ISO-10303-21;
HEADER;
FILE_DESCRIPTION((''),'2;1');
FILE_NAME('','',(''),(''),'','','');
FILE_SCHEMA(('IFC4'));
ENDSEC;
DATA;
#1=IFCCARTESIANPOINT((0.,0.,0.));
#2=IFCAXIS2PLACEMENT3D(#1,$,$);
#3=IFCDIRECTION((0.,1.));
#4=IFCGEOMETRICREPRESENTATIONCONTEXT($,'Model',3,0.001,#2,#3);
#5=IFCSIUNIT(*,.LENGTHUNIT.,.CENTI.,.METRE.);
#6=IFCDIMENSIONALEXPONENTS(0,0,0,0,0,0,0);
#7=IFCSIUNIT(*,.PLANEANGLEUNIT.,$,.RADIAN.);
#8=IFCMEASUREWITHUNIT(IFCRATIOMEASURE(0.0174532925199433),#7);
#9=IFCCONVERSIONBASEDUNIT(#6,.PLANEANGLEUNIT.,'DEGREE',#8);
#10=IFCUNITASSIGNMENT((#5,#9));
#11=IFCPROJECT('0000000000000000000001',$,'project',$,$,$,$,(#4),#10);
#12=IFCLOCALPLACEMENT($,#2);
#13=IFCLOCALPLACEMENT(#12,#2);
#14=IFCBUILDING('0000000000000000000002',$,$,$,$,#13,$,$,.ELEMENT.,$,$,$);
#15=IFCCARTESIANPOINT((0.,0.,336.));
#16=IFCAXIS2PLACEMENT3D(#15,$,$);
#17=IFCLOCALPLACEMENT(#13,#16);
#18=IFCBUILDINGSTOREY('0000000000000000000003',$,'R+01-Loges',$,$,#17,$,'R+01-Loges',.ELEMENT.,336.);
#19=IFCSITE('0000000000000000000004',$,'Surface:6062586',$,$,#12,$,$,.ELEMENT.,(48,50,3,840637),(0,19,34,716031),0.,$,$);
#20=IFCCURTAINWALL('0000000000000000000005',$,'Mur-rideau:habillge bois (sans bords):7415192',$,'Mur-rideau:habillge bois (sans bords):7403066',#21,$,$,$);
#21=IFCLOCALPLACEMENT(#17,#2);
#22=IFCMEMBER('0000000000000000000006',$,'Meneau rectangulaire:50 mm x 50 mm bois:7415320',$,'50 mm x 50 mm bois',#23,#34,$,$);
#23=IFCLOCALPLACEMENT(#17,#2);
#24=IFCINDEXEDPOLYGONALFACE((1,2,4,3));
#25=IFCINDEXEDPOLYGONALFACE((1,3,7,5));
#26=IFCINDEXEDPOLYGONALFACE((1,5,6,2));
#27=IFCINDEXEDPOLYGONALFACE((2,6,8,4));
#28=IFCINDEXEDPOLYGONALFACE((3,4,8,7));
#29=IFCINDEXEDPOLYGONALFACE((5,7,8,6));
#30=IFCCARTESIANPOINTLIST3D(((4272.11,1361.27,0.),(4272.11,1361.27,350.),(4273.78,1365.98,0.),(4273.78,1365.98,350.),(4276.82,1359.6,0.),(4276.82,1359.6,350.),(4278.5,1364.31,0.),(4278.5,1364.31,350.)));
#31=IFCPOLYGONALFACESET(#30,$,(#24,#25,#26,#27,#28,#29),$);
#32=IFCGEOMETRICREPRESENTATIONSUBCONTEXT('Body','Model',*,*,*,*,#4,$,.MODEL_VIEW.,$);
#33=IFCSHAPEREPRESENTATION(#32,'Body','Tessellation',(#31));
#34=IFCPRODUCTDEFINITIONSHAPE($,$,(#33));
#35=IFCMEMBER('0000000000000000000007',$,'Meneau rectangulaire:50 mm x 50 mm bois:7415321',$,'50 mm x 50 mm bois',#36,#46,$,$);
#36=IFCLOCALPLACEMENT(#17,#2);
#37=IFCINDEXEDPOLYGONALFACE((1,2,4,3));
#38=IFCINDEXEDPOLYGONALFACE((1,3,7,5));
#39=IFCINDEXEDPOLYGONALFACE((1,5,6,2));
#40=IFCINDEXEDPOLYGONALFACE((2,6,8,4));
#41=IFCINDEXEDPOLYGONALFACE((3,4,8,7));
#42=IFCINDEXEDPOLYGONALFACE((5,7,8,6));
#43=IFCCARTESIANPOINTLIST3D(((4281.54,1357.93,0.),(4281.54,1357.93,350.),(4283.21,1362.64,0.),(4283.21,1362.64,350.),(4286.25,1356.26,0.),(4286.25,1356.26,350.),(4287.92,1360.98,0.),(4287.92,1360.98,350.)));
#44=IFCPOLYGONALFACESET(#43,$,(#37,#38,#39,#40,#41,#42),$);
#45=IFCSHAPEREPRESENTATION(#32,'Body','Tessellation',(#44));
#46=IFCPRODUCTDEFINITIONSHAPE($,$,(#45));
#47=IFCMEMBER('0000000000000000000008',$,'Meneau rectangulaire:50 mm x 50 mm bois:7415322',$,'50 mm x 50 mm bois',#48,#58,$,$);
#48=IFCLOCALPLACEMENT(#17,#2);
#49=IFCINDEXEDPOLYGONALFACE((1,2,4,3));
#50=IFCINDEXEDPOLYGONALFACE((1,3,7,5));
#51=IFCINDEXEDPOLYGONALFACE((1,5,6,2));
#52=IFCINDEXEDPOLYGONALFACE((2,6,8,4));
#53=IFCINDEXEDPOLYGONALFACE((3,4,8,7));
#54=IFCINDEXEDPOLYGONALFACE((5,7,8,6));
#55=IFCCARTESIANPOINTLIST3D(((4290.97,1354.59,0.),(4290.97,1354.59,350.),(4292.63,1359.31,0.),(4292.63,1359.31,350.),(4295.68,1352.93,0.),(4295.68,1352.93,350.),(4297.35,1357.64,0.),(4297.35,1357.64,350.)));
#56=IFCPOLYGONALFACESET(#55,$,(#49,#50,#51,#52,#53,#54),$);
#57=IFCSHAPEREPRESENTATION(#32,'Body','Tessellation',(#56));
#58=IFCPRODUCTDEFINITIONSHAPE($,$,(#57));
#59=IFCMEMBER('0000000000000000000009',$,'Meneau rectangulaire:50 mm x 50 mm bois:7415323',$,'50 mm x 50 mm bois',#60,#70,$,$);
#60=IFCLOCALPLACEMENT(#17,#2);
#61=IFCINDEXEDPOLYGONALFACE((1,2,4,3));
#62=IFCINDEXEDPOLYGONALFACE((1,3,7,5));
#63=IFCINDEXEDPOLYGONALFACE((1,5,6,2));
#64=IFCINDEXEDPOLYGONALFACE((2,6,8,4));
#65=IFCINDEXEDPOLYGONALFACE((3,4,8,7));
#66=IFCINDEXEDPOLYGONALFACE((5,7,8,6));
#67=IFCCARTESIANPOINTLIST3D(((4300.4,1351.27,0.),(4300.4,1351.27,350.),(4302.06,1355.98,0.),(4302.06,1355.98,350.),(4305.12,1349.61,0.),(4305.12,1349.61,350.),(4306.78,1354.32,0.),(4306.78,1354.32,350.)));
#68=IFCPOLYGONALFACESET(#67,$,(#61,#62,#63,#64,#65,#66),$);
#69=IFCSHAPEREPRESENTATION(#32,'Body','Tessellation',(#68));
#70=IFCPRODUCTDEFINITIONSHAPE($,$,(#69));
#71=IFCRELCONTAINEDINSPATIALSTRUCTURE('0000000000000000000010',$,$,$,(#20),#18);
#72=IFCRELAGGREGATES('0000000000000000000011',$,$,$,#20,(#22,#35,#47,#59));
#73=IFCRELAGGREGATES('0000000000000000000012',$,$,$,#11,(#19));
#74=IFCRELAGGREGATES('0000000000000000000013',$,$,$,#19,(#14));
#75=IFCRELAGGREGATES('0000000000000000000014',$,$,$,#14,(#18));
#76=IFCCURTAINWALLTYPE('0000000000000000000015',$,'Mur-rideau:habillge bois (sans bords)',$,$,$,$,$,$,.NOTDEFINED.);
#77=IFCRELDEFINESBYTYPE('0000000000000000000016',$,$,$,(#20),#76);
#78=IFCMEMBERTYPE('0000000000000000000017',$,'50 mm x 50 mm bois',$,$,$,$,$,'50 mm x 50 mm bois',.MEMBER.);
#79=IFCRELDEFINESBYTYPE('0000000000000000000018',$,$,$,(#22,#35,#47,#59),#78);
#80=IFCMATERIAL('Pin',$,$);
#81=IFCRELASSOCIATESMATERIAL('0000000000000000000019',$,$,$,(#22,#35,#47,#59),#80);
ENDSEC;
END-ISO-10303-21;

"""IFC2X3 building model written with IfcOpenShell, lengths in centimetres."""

from ifc_helpers import new_model, entity, si_unit, converted_unit, direction, frame, origin, origin_2d_with_axis, place, context, subcontext, project, spatial, rectangle, extrude, source, transform, mapped, material, type_object, type_shapes, element, aggregate, save


model = new_model("IFC2X3")

# Units and contexts
model_context = context("Model", 3, precision=0.001, world=origin(), true_north=direction((0.0, 1.0)))
body_context = subcontext(model_context, "Body", "Model", "MODEL_VIEW")
ifc_project = project(units=[si_unit("LENGTHUNIT", "METRE", prefix="CENTI"), converted_unit("PLANEANGLEUNIT", "DEGREE", entity("IfcRatioMeasure", 0.0174532925199433), si_unit("PLANEANGLEUNIT", "RADIAN"), dimensions=[0, 0, 0, 0, 0, 0, 0])], contexts=[model_context])

# Site, building, storey
site_placement = place(None, origin())
site = spatial("IfcSite", under=ifc_project, at=site_placement, Name="Surface:6062586", CompositionType="ELEMENT", RefLatitude=(48, 50, 3, 840637), RefLongitude=(0, 19, 34, 716031), RefElevation=0.0)
building_placement = place(site_placement, origin())
building = spatial("IfcBuilding", under=site, at=building_placement, CompositionType="ELEMENT")
storey_placement = place(building_placement, frame((0.0, 0.0, 336.0)))
storey = spatial("IfcBuildingStorey", under=building, at=storey_placement, Name="R+01-Loges", LongName="R+01-Loges", CompositionType="ELEMENT", Elevation=336.0)

# Curtain wall, members
curtain_wall_type = type_object("IfcCurtainWallType", Name="Mur-rideau:habillge bois (sans bords)", PredefinedType="NOTDEFINED")
curtain_wall_placement = place(storey_placement, frame((0.0, 0.0, -336.0)))
curtain_wall = element("IfcCurtainWall", 1, at=curtain_wall_placement, inside=storey, type_object=curtain_wall_type, Name="Mur-rideau:habillge bois (sans bords):7415192", ObjectType="Mur-rideau:habillge bois (sans bords):7403066")
ifc_material_1 = material(Name="Pin")
member_type_1 = type_object("IfcMemberType", Name="50 mm x 50 mm bois", ElementType="50 mm x 50 mm bois", PredefinedType="MEMBER")
shared_shape_1 = source(origin(), body_context, "Body", "SweptSolid", [
    extrude(rectangle(XDim=5.0, YDim=5.0, at=origin_2d_with_axis()), frame((0.0, 0.0, -350.0), z_axis=(0.0, 0.0, 1.0), x_axis=(0.0, -1.0, 0.0)), (0.0, 0.0, 1.0), 350.0),
])
type_shapes(member_type_1, [shared_shape_1])
member_1_placement = place(storey_placement, frame((4275.3, 1362.79, 0.0), z_axis=(0.0, 0.0, -1.0), x_axis=(0.942461, -0.334315, 0.0)))
member_1 = element("IfcMember", 2, at=member_1_placement, type_object=member_type_1, material=ifc_material_1, Name="Meneau rectangulaire:50 mm x 50 mm bois:7415320", ObjectType="50 mm x 50 mm bois", context=body_context, shape_type="MappedRepresentation", body=[
    mapped(shared_shape_1, transform((0.0, 0.0, 0.0), scale=1.0)),
])
member_2_placement = place(storey_placement, frame((4284.73, 1359.45, 0.0), z_axis=(0.0, 0.0, -1.0), x_axis=(0.942707, -0.333622, 0.0)))
member_2 = element("IfcMember", 3, at=member_2_placement, type_object=member_type_1, material=ifc_material_1, Name="Meneau rectangulaire:50 mm x 50 mm bois:7415321", ObjectType="50 mm x 50 mm bois", context=body_context, shape_type="MappedRepresentation", body=[
    mapped(shared_shape_1, transform((0.0, 0.0, 0.0), scale=1.0)),
])
member_3_placement = place(storey_placement, frame((4294.16, 1356.12, 0.0), z_axis=(0.0, 0.0, -1.0), x_axis=(0.942952, -0.332928, 0.0)))
member_3 = element("IfcMember", 4, at=member_3_placement, type_object=member_type_1, material=ifc_material_1, Name="Meneau rectangulaire:50 mm x 50 mm bois:7415322", ObjectType="50 mm x 50 mm bois", context=body_context, shape_type="MappedRepresentation", body=[
    mapped(shared_shape_1, transform((0.0, 0.0, 0.0), scale=1.0)),
])
member_4_placement = place(storey_placement, frame((4303.59, 1352.79, 0.0), z_axis=(0.0, 0.0, -1.0), x_axis=(0.943197, -0.332234, 0.0)))
member_4 = element("IfcMember", 5, at=member_4_placement, type_object=member_type_1, material=ifc_material_1, Name="Meneau rectangulaire:50 mm x 50 mm bois:7415323", ObjectType="50 mm x 50 mm bois", context=body_context, shape_type="MappedRepresentation", body=[
    mapped(shared_shape_1, transform((0.0, 0.0, 0.0), scale=1.0)),
])
aggregate(curtain_wall, [member_1, member_2, member_3, member_4])

save(model, "model.ifc")
